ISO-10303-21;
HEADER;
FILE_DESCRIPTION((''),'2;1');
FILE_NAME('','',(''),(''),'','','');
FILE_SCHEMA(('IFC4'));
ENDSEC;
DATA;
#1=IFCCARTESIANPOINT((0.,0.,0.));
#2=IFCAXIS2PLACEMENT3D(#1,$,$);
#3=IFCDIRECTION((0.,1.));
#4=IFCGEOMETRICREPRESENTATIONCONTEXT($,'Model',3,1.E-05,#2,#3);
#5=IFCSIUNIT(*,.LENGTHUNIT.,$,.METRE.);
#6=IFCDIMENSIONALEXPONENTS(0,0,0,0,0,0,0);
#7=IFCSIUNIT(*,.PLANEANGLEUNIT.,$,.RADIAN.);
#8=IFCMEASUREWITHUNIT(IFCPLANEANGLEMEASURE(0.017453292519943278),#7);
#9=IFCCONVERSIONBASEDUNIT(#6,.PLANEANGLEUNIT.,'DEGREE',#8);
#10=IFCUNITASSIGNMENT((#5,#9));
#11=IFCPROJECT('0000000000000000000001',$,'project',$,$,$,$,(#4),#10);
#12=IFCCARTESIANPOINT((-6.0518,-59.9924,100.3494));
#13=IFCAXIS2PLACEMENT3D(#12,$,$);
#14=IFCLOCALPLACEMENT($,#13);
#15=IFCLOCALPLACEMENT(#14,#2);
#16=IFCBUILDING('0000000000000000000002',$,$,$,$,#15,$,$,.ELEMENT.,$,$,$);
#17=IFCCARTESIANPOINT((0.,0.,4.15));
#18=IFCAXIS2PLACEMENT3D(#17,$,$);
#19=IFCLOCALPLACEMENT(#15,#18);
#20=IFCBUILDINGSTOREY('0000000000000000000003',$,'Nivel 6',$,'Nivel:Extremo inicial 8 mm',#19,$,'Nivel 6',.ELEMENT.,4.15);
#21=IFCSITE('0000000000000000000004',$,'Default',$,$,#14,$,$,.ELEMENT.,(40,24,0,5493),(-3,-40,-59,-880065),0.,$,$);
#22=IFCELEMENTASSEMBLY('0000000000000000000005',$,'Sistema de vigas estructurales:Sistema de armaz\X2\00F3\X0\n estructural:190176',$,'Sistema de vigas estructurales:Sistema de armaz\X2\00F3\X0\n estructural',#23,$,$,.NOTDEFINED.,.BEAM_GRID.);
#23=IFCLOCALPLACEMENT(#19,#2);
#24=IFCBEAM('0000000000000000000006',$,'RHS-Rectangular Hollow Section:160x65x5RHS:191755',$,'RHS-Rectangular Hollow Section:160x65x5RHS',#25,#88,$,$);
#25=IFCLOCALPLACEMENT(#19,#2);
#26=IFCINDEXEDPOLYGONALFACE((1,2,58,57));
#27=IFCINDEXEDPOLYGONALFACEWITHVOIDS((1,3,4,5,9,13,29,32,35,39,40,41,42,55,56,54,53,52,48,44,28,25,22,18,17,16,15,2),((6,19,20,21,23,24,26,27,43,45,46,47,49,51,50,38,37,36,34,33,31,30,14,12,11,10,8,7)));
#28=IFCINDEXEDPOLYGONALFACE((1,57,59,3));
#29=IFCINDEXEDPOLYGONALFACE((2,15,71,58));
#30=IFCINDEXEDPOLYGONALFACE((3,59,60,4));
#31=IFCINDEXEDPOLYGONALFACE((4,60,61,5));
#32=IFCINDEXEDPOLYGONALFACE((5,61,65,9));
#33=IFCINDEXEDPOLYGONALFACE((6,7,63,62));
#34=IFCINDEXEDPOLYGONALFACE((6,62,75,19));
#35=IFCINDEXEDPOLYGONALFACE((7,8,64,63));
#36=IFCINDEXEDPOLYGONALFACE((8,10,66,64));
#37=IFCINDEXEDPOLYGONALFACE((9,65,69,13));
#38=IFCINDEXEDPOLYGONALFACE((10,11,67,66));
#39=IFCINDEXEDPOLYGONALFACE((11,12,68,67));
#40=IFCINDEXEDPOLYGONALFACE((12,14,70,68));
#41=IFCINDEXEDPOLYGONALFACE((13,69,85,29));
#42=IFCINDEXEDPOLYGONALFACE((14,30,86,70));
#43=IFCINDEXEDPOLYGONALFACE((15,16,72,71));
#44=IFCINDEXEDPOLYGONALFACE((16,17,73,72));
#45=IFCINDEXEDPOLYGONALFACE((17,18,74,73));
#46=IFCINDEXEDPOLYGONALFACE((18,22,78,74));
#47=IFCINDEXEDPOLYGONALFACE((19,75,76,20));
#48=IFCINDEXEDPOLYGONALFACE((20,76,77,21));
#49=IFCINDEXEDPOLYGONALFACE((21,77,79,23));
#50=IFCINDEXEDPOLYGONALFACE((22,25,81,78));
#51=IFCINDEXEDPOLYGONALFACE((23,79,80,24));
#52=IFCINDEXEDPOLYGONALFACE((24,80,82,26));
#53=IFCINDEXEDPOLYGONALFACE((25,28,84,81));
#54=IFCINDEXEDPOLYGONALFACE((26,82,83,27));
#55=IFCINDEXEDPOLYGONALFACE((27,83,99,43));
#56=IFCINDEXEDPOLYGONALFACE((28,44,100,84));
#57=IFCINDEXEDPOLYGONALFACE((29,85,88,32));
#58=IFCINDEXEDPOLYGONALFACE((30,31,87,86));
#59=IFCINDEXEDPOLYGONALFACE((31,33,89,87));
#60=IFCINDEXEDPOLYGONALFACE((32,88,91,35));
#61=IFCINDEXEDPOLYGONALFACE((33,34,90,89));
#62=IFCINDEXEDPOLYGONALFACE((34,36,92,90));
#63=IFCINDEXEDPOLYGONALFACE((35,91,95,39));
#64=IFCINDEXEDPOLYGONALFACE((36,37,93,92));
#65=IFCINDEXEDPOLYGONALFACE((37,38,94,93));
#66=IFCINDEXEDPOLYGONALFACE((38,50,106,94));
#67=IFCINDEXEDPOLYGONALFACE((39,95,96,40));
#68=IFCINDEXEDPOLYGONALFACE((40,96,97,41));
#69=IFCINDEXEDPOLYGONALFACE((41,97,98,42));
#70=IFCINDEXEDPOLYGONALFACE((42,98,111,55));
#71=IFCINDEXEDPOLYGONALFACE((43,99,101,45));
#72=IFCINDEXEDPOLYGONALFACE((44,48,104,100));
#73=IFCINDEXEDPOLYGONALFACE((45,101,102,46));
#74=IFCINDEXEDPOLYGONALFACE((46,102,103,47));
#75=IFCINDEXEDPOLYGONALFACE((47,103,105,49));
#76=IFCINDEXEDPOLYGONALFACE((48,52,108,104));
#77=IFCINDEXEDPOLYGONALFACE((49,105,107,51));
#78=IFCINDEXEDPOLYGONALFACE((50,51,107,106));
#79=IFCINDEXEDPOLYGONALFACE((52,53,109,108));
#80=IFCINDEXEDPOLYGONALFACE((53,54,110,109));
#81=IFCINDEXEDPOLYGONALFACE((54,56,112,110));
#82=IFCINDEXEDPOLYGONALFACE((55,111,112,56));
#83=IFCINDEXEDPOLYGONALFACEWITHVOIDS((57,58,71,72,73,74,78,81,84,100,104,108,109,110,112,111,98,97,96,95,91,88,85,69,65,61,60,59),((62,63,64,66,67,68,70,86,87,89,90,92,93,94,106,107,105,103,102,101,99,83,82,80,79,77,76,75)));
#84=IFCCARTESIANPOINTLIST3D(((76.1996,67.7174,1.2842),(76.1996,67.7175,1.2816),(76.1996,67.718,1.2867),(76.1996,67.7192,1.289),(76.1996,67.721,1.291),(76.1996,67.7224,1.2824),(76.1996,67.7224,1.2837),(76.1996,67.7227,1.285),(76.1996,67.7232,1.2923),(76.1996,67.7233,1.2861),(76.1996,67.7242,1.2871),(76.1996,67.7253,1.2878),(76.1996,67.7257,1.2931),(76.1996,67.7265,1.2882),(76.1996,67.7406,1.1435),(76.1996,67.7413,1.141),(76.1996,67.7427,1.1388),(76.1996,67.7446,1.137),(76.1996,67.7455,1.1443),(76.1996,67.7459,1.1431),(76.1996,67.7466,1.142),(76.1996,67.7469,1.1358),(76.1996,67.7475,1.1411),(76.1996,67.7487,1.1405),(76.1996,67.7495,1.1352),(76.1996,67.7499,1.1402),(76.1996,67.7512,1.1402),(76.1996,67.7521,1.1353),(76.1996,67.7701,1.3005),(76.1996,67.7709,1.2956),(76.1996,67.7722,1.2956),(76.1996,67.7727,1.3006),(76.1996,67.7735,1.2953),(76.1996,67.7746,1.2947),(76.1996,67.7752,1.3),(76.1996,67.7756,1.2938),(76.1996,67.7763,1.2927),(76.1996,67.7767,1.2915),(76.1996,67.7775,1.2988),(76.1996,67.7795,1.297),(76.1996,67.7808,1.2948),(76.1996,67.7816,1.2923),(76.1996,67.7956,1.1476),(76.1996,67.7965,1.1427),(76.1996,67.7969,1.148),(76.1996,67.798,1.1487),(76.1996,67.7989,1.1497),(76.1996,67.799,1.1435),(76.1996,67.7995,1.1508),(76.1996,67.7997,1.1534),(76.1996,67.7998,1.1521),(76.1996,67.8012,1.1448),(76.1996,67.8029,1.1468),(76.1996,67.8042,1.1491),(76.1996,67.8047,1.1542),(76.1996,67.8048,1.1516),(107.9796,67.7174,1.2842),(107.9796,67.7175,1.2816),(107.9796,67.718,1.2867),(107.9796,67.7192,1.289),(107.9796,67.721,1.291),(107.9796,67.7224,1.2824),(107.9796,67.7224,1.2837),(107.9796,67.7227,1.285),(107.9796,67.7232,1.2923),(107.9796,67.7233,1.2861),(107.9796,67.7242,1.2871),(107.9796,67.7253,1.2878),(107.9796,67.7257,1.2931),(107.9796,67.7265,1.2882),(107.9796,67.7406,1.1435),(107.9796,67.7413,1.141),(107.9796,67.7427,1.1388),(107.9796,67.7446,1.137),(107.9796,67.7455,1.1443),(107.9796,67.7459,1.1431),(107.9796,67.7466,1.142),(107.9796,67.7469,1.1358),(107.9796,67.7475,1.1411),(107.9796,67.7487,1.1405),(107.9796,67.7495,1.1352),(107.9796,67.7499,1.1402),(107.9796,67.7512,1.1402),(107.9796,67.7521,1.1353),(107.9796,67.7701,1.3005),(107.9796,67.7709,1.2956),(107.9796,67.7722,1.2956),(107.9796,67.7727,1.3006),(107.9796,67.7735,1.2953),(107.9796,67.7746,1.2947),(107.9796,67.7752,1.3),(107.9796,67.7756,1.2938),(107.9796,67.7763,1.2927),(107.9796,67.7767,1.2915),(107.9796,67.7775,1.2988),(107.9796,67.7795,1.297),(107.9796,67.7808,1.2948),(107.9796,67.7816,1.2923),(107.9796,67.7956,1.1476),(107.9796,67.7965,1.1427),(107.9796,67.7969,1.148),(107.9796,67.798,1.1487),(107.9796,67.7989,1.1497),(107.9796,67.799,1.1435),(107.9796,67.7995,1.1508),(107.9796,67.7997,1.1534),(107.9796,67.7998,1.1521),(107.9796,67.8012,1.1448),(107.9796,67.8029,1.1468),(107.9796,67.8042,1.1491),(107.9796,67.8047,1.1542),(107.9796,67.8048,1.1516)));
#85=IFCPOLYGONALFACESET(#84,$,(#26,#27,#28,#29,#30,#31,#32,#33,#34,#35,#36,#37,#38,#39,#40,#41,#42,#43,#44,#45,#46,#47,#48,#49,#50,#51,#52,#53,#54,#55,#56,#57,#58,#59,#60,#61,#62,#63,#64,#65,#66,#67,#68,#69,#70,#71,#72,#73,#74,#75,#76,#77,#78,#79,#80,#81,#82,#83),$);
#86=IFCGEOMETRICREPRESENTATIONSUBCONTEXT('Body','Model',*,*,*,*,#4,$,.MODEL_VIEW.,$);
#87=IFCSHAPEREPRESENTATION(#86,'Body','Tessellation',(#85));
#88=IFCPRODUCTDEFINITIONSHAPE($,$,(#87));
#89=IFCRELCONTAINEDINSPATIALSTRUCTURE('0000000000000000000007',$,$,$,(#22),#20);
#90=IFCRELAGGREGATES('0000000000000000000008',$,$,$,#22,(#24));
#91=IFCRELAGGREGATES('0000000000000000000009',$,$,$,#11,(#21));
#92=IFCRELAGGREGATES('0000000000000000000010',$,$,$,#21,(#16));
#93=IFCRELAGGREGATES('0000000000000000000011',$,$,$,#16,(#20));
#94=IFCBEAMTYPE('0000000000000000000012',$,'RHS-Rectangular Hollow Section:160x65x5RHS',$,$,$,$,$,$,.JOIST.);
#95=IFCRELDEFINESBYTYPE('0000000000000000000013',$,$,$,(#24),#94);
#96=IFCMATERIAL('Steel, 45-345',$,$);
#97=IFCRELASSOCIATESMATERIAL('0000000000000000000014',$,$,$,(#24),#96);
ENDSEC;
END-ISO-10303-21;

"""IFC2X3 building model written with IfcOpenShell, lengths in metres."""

from ifc_helpers import new_model, entity, si_unit, converted_unit, direction, frame, frame_2d, origin, place, context, subcontext, project, spatial, polyline, circle_curve, parameter, trimmed, segment, composite_curve, outline, extrude, material, type_object, element, aggregate, save


model = new_model("IFC2X3")

# Units and contexts
model_context = context("Model", 3, precision=1e-05, world=origin(), true_north=direction((0.0, 1.0)))
body_context = subcontext(model_context, "Body", "Model", "MODEL_VIEW")
ifc_project = project(units=[si_unit("LENGTHUNIT", "METRE"), converted_unit("PLANEANGLEUNIT", "DEGREE", entity("IfcPlaneAngleMeasure", 0.017453292519943278), si_unit("PLANEANGLEUNIT", "RADIAN"), dimensions=[0, 0, 0, 0, 0, 0, 0])], contexts=[model_context])

# Site, building, storey
site_placement = place(None, frame((-6.0518, -59.9924, 100.3494)))
site = spatial("IfcSite", under=ifc_project, at=site_placement, Name="Default", CompositionType="ELEMENT", RefLatitude=(40, 24, 0, 5493), RefLongitude=(-3, -40, -59, -880065), RefElevation=0.0)
building_placement = place(site_placement, origin())
building = spatial("IfcBuilding", under=site, at=building_placement, CompositionType="ELEMENT")
storey_placement = place(building_placement, frame((0.0, 0.0, 4.15)))
storey = spatial("IfcBuildingStorey", under=building, at=storey_placement, Name="Nivel 6", ObjectType="Nivel:Extremo inicial 8 mm", LongName="Nivel 6", CompositionType="ELEMENT", Elevation=4.15)

# Shared definitions
ifc_material_1 = material(Name="Steel, 45-345")

# Element assembly, beam
assembly_placement = place(storey_placement, origin())
assembly = element("IfcElementAssembly", 1, at=assembly_placement, inside=storey, Name="Sistema de vigas estructurales:Sistema de armazón estructural:190176", ObjectType="Sistema de vigas estructurales:Sistema de armazón estructural", AssemblyPlace="NOTDEFINED", PredefinedType="BEAM_GRID")
beam_type_1 = type_object("IfcBeamType", Name="RHS-Rectangular Hollow Section:160x65x5RHS", PredefinedType="JOIST")
beam_1_placement = place(assembly_placement, frame((76.1996, 67.8006, 0.9812)))
beam_1 = element("IfcBeam", 2, at=beam_1_placement, type_object=beam_type_1, material=ifc_material_1, Name="RHS-Rectangular Hollow Section:160x65x5RHS:191755", ObjectType="RHS-Rectangular Hollow Section:160x65x5RHS", context=body_context, shape_type="SweptSolid", body=[
    extrude(outline(composite_curve([segment(trimmed(circle_curve(frame_2d((-0.0225, -0.07), x_axis=(1.0, 0.0)), 0.01), [parameter(180.0)], [parameter(270.0)], True, "PARAMETER"), True, "CONTINUOUS"), segment(polyline([(-0.0225, -0.08), (0.0225, -0.08)]), True, "CONTINUOUS"), segment(trimmed(circle_curve(frame_2d((0.0225, -0.07), x_axis=(1.0, 0.0)), 0.01), [parameter(270.0)], [parameter(0.0)], True, "PARAMETER"), True, "CONTINUOUS"), segment(polyline([(0.0325, -0.07), (0.0325, 0.07)]), True, "CONTINUOUS"), segment(trimmed(circle_curve(frame_2d((0.0225, 0.07), x_axis=(1.0, 0.0)), 0.01), [parameter(360.0)], [parameter(90.0)], True, "PARAMETER"), True, "CONTINUOUS"), segment(polyline([(0.0225, 0.08), (-0.0225, 0.08)]), True, "CONTINUOUS"), segment(trimmed(circle_curve(frame_2d((-0.0225, 0.07), x_axis=(1.0, 0.0)), 0.01), [parameter(90.0)], [parameter(180.0)], True, "PARAMETER"), True, "CONTINUOUS"), segment(polyline([(-0.0325, 0.07), (-0.0325, -0.07)]), True, "CONTINUOUS")], self_intersect=False), holes=[composite_curve([segment(polyline([(0.0225, -0.075), (-0.0225, -0.075)]), True, "CONTINUOUS"), segment(trimmed(circle_curve(frame_2d((-0.0225, -0.07), x_axis=(1.0, 0.0)), 0.005), [parameter(180.0)], [parameter(270.0)], True, "PARAMETER"), False, "CONTINUOUS"), segment(polyline([(-0.0275, -0.07), (-0.0275, 0.07)]), True, "CONTINUOUS"), segment(trimmed(circle_curve(frame_2d((-0.0225, 0.07), x_axis=(1.0, 0.0)), 0.005), [parameter(90.0)], [parameter(180.0)], True, "PARAMETER"), False, "CONTINUOUS"), segment(polyline([(-0.0225, 0.075), (0.0225, 0.075)]), True, "CONTINUOUS"), segment(trimmed(circle_curve(frame_2d((0.0225, 0.07), x_axis=(1.0, 0.0)), 0.005), [parameter(0.0)], [parameter(90.0)], True, "PARAMETER"), False, "CONTINUOUS"), segment(polyline([(0.0275, 0.07), (0.0275, -0.07)]), True, "CONTINUOUS"), segment(trimmed(circle_curve(frame_2d((0.0225, -0.07), x_axis=(1.0, 0.0)), 0.005), [parameter(270.0)], [parameter(0.0)], True, "PARAMETER"), False, "CONTINUOUS")], self_intersect=False)]), frame((0.0, -0.0396, 0.2367), z_axis=(1.0, 0.0, 0.0), x_axis=(0.0, -0.986325, -0.16481)), (0.0, 0.0, 1.0), 31.78),
])
aggregate(assembly, [beam_1])

save(model, "model.ifc")
